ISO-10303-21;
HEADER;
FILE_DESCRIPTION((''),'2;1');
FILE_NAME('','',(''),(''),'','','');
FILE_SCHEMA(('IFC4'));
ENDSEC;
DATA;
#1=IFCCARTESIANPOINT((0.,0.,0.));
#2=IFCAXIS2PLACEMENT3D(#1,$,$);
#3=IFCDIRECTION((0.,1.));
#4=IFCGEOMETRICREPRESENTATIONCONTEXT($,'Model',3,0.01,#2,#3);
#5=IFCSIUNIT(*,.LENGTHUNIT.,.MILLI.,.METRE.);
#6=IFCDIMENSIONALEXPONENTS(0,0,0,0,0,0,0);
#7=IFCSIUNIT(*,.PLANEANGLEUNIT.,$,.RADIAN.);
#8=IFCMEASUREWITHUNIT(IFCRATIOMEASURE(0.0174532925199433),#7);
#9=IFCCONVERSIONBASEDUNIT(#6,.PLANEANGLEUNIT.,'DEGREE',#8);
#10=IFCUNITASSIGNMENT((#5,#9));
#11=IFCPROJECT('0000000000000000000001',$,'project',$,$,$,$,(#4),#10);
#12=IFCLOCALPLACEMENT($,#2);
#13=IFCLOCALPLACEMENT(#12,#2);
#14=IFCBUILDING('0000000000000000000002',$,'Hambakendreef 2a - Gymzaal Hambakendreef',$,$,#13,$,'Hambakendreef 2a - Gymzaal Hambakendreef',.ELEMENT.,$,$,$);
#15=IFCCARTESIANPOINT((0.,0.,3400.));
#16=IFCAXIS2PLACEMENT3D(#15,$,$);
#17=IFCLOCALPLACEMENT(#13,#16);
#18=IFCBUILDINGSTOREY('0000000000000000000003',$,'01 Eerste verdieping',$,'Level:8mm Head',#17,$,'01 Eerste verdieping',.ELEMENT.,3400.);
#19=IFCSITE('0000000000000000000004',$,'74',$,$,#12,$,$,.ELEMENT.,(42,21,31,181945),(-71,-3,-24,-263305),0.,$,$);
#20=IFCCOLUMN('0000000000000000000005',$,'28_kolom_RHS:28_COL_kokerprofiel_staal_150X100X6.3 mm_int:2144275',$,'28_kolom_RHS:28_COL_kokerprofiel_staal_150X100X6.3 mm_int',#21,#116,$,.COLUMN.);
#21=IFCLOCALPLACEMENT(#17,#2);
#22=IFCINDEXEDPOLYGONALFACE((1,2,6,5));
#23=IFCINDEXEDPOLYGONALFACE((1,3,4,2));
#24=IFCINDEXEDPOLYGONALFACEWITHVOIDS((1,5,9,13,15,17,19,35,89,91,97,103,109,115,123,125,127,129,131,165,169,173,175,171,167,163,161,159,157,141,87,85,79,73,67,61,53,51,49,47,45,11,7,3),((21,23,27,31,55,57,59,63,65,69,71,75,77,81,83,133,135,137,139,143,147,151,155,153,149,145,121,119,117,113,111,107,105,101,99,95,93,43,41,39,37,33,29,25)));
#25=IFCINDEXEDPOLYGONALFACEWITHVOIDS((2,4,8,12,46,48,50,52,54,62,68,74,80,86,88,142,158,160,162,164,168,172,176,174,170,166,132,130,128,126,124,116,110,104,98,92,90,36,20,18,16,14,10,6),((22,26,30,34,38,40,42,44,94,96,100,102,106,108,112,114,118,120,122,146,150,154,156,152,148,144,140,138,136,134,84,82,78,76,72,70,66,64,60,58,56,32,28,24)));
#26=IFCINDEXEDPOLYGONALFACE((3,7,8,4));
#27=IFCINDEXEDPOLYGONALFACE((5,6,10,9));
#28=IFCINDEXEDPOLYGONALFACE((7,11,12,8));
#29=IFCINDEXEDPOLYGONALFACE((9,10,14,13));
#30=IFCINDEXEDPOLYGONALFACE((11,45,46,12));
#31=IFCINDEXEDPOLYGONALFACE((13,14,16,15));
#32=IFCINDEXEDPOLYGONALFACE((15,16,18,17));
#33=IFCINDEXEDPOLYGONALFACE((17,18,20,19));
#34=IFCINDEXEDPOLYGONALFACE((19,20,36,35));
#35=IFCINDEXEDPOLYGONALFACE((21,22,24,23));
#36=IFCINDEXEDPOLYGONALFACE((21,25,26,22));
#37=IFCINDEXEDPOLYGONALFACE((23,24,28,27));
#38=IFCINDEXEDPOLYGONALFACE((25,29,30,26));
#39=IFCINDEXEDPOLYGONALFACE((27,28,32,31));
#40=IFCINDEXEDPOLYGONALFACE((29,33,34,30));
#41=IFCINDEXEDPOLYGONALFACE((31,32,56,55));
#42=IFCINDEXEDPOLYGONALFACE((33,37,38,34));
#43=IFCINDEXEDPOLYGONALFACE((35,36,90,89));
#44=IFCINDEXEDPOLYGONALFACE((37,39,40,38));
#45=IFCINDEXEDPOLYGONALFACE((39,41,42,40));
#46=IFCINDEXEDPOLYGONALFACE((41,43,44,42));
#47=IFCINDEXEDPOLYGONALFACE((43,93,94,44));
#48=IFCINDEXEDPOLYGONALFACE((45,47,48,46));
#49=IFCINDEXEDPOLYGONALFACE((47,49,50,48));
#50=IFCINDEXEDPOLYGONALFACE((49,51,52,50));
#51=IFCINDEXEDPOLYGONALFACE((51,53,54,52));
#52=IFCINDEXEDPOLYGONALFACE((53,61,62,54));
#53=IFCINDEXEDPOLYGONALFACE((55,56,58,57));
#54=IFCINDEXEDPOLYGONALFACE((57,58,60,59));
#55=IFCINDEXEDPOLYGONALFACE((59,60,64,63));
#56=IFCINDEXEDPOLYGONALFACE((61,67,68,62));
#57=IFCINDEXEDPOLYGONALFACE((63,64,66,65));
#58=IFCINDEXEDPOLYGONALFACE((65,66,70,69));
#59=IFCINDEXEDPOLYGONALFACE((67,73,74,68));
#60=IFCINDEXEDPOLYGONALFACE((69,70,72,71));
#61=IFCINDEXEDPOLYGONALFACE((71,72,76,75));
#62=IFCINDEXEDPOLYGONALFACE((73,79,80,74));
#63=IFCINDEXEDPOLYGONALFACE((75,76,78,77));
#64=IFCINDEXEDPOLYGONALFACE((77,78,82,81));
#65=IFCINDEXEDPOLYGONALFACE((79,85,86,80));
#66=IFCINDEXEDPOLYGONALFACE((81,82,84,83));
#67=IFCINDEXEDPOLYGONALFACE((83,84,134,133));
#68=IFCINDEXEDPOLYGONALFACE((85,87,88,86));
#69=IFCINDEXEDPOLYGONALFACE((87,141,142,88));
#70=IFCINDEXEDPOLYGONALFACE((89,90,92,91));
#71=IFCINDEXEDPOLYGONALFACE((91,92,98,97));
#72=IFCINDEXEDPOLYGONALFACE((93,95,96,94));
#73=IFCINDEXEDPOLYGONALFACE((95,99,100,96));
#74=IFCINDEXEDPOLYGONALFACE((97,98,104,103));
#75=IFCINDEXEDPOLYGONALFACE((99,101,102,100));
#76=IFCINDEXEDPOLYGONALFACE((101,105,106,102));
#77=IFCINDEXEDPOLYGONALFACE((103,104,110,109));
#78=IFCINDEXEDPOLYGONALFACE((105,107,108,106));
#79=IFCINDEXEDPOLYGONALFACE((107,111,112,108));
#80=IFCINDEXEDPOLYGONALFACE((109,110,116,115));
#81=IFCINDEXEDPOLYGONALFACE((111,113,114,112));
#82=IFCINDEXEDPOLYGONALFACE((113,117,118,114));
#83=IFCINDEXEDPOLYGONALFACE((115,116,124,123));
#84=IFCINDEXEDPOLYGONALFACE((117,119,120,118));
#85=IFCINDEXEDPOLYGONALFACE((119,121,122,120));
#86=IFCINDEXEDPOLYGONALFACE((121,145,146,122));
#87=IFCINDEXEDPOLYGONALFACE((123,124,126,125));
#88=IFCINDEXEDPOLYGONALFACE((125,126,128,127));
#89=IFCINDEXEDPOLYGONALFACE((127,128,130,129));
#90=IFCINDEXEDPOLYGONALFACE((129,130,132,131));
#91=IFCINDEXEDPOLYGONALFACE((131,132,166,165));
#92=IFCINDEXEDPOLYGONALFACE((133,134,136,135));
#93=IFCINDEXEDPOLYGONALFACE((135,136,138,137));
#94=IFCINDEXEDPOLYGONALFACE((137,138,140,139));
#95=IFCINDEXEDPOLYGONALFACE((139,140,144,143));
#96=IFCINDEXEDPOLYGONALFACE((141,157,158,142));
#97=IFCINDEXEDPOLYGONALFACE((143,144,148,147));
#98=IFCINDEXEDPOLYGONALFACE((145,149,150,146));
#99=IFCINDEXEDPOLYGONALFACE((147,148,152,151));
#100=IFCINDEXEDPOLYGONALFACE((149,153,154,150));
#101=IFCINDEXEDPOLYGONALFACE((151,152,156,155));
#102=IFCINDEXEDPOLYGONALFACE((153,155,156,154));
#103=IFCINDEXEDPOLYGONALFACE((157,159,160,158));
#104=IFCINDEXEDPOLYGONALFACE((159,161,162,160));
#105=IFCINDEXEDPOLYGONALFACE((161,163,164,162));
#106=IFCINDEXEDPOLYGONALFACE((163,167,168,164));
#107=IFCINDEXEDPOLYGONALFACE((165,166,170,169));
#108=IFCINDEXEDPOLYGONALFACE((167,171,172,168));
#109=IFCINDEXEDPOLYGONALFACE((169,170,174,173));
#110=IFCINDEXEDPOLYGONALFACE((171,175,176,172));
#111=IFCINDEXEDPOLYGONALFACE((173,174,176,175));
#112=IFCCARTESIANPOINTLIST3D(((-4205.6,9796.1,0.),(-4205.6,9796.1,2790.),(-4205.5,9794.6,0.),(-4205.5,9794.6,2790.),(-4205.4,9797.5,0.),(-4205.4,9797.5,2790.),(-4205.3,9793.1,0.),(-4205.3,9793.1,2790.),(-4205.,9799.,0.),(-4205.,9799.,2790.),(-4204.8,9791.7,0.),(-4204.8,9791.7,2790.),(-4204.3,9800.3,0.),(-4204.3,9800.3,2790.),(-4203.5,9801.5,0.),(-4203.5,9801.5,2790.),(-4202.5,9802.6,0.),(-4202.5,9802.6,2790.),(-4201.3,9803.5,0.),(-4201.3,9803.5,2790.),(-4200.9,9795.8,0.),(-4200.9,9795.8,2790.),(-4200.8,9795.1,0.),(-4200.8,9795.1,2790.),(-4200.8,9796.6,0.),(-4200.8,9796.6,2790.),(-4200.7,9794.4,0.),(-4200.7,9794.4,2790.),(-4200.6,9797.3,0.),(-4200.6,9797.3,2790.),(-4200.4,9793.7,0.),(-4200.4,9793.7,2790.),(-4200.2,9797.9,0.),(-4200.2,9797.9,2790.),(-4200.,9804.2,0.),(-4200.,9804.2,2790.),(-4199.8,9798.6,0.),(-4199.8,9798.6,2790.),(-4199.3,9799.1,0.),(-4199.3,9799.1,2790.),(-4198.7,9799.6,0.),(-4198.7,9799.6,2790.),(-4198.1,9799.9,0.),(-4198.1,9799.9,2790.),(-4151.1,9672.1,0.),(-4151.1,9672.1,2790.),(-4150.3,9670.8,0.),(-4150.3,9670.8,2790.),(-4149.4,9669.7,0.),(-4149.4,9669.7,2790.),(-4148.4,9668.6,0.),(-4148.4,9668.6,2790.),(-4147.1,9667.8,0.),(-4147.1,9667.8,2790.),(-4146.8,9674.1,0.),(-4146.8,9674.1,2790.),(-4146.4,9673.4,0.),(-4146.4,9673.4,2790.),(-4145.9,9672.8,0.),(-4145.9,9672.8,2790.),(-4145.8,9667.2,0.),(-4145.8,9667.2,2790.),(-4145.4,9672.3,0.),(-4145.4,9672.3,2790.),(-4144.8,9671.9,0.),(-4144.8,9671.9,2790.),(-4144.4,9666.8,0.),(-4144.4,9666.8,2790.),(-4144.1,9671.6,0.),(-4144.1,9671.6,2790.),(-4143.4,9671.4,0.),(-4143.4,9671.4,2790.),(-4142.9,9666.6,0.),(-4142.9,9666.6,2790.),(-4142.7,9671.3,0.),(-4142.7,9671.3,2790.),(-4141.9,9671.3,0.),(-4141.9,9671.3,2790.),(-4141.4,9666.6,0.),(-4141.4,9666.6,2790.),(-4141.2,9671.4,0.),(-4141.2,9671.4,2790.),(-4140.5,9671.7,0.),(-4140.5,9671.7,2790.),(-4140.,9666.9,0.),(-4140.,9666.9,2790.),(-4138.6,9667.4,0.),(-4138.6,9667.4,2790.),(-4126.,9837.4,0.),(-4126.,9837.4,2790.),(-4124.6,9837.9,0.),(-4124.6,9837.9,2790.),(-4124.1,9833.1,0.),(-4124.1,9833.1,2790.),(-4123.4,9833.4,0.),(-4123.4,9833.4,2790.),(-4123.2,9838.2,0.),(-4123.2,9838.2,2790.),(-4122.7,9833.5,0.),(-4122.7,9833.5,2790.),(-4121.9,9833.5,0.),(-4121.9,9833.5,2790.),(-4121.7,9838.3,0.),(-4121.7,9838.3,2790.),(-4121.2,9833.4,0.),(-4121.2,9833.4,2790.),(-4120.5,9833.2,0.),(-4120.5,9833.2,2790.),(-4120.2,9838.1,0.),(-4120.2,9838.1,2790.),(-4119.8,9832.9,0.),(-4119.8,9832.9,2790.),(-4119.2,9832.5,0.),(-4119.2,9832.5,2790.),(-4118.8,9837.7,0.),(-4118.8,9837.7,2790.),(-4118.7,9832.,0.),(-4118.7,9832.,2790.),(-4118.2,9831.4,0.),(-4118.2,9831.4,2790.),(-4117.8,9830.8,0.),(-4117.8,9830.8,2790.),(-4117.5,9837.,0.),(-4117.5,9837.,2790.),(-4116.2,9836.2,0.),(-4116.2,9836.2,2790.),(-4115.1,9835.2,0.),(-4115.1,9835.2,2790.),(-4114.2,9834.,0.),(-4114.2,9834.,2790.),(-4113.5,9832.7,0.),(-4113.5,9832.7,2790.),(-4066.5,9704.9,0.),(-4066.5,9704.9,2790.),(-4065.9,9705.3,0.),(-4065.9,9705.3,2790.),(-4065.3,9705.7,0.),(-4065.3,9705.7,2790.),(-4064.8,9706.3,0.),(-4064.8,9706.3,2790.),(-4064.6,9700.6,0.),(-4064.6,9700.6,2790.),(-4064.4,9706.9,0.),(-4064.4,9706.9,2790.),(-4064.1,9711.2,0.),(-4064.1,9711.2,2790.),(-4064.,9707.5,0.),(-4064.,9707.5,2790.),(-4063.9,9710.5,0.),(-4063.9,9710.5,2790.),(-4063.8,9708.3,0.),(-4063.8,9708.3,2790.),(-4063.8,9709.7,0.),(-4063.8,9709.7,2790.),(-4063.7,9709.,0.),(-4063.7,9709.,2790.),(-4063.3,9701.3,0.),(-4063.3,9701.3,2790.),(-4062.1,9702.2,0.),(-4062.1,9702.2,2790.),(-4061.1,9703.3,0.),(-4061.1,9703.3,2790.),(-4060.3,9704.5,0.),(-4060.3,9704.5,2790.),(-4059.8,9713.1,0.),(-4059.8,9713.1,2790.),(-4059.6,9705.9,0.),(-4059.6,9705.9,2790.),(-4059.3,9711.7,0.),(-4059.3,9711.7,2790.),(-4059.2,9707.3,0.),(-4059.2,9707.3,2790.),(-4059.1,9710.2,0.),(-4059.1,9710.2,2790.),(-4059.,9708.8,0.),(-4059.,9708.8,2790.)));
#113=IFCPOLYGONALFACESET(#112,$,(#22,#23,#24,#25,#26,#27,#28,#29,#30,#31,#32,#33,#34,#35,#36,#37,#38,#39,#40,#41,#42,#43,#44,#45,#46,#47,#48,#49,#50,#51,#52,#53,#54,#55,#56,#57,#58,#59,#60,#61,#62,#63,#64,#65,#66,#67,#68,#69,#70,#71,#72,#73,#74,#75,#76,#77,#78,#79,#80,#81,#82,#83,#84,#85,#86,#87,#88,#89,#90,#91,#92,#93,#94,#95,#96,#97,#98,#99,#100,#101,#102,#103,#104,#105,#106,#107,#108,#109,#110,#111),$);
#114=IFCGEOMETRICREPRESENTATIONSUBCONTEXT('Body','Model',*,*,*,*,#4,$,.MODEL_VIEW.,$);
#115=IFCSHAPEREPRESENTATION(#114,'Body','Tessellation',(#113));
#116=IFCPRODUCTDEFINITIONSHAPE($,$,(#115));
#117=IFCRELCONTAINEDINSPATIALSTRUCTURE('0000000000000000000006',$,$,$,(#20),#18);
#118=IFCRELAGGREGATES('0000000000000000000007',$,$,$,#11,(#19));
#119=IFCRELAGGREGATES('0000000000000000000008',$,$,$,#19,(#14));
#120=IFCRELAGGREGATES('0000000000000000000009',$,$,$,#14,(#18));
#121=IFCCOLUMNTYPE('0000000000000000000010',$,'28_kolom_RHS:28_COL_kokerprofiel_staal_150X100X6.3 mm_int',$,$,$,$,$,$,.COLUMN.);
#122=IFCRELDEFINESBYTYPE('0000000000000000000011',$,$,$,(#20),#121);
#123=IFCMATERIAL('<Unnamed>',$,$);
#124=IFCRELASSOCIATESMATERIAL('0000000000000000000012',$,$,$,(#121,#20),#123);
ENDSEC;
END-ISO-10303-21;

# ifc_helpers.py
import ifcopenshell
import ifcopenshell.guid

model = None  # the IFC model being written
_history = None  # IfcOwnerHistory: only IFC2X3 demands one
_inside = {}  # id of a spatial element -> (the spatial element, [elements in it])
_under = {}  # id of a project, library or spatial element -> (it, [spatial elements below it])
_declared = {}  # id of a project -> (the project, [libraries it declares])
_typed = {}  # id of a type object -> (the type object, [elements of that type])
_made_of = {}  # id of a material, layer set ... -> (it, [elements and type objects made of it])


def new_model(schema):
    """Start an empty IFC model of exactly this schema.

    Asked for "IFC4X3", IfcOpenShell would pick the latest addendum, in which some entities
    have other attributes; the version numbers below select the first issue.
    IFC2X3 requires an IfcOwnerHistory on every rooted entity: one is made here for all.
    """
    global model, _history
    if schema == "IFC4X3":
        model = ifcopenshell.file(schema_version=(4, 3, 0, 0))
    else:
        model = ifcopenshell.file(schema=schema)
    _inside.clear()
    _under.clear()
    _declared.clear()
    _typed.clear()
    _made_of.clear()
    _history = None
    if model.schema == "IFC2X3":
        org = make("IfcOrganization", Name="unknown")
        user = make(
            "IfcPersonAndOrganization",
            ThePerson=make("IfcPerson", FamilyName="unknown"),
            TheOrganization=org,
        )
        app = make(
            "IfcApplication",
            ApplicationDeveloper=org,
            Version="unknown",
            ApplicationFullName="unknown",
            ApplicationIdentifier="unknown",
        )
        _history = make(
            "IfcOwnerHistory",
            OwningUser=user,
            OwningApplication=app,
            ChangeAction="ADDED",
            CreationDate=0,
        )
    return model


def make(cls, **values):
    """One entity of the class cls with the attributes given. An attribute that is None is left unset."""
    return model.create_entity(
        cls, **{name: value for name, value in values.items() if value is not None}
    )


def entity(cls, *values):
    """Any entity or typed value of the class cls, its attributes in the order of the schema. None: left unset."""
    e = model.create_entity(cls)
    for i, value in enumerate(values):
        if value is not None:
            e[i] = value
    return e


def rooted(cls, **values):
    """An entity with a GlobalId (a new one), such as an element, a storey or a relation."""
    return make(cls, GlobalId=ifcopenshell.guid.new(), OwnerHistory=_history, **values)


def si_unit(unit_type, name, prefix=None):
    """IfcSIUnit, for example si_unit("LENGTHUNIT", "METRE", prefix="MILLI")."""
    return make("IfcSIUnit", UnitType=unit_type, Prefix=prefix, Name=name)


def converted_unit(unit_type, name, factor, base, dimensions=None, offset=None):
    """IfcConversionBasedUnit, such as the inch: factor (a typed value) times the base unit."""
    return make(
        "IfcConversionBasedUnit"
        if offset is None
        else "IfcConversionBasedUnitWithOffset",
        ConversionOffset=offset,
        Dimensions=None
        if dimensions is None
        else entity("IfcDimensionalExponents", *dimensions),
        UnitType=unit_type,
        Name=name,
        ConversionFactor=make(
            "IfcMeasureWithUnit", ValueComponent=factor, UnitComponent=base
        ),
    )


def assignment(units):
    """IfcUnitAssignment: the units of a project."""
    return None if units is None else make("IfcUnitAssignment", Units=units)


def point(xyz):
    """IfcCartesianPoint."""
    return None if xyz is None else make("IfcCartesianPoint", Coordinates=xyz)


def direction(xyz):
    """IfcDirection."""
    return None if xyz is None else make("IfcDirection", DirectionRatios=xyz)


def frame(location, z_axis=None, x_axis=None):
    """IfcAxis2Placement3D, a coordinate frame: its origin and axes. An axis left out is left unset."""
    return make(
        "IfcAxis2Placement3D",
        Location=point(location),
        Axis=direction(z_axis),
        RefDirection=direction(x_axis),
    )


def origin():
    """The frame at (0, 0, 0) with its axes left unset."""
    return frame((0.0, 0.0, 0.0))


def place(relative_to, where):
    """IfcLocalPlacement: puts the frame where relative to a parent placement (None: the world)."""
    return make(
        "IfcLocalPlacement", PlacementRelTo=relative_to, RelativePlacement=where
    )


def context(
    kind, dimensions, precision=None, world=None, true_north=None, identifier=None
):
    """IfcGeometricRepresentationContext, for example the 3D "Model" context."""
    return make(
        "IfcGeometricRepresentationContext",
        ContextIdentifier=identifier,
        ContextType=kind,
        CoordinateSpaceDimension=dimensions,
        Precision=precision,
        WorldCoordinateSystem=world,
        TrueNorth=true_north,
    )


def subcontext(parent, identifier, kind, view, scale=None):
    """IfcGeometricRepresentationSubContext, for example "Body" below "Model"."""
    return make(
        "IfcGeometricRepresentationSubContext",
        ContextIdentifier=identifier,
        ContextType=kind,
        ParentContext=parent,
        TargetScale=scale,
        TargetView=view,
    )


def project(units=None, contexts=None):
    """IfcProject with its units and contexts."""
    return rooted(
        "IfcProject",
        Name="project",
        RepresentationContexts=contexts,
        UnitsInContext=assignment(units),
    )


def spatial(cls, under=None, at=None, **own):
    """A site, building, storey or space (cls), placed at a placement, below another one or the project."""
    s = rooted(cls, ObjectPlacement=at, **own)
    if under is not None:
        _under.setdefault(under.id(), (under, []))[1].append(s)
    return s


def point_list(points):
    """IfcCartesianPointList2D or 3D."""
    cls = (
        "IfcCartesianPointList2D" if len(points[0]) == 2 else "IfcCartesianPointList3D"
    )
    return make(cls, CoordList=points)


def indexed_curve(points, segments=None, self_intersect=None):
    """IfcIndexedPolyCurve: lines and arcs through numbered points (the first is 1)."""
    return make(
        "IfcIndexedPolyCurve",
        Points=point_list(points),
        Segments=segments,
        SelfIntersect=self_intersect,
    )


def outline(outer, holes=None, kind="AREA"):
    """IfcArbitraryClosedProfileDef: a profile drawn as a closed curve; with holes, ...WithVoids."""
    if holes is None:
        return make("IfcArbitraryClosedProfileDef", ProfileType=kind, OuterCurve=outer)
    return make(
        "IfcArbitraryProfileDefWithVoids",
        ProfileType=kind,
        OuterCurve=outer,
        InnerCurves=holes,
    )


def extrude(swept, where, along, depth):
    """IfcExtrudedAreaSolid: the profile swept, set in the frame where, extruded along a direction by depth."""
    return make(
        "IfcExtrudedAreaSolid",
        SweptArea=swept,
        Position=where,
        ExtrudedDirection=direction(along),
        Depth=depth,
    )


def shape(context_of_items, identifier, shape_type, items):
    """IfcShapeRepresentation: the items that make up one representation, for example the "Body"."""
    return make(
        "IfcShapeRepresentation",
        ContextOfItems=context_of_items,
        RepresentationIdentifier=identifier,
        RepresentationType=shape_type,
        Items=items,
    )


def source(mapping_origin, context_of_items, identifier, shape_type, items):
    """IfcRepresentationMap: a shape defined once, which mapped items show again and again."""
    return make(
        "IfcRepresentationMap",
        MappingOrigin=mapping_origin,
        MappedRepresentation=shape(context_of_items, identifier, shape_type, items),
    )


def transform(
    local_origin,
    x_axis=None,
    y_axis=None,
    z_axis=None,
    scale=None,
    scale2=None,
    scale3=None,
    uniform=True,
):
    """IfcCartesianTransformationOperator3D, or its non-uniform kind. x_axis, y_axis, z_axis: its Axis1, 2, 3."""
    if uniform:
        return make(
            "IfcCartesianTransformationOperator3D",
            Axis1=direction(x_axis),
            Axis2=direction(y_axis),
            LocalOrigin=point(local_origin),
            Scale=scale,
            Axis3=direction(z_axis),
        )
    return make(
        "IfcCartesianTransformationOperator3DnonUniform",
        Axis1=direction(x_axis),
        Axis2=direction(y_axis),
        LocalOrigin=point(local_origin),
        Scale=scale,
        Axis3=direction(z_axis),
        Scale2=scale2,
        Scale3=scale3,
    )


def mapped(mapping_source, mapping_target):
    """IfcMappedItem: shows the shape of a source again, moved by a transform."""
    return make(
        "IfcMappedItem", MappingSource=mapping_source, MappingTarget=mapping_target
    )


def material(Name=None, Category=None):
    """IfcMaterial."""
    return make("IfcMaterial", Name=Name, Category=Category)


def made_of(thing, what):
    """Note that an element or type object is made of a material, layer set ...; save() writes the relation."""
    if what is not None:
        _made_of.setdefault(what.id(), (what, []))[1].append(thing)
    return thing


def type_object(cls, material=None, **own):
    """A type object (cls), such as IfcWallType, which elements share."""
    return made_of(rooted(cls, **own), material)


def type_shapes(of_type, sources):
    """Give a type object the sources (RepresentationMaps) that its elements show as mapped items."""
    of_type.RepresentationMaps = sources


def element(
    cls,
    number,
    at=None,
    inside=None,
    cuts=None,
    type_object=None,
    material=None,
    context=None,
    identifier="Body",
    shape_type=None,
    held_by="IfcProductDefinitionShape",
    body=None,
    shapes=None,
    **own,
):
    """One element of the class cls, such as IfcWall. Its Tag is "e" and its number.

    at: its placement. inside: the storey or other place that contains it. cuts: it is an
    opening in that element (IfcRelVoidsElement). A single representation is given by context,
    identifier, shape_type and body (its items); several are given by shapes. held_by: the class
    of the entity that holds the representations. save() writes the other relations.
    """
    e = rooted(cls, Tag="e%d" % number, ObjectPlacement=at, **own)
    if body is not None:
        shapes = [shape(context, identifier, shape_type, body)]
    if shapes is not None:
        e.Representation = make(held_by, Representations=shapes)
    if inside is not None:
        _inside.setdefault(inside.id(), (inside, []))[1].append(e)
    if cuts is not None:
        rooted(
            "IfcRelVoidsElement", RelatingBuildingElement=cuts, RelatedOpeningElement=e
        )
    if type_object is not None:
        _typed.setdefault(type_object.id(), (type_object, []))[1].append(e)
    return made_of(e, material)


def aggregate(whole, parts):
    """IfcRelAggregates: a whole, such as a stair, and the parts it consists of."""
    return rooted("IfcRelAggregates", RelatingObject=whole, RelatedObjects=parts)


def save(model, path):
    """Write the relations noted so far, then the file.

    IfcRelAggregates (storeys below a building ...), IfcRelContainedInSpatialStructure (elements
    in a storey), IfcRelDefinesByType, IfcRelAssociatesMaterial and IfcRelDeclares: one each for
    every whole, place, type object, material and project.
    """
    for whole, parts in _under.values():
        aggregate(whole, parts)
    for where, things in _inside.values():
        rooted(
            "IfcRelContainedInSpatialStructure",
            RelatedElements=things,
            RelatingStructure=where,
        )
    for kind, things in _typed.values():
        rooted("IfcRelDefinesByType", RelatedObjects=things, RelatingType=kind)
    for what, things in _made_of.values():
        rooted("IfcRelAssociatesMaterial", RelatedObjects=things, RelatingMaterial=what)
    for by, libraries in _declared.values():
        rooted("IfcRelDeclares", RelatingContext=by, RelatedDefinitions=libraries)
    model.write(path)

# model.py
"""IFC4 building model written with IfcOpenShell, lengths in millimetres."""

from ifc_helpers import new_model, entity, si_unit, converted_unit, direction, frame, origin, place, context, subcontext, project, spatial, indexed_curve, outline, extrude, source, transform, mapped, material, type_object, type_shapes, element, save


model = new_model("IFC4")

# Units and contexts
model_context = context("Model", 3, precision=0.01, world=origin(), true_north=direction((0.0, 1.0)))
body_context = subcontext(model_context, "Body", "Model", "MODEL_VIEW")
ifc_project = project(units=[si_unit("LENGTHUNIT", "METRE", prefix="MILLI"), converted_unit("PLANEANGLEUNIT", "DEGREE", entity("IfcRatioMeasure", 0.0174532925199433), si_unit("PLANEANGLEUNIT", "RADIAN"), dimensions=[0, 0, 0, 0, 0, 0, 0])], contexts=[model_context])

# Site, building, storey
site_placement = place(None, origin())
site = spatial("IfcSite", under=ifc_project, at=site_placement, Name="74", CompositionType="ELEMENT", RefLatitude=(42, 21, 31, 181945), RefLongitude=(-71, -3, -24, -263305), RefElevation=0.0)
building_placement = place(site_placement, origin())
building = spatial("IfcBuilding", under=site, at=building_placement, Name="Hambakendreef 2a - Gymzaal Hambakendreef", LongName="Hambakendreef 2a - Gymzaal Hambakendreef", CompositionType="ELEMENT")
storey_placement = place(building_placement, frame((0.0, 0.0, 3400.0)))
storey = spatial("IfcBuildingStorey", under=building, at=storey_placement, Name="01 Eerste verdieping", ObjectType="Level:8mm Head", LongName="01 Eerste verdieping", CompositionType="ELEMENT", Elevation=3400.0)

# Column
ifc_material_1 = material(Name="<Unnamed>")
column_type = type_object("IfcColumnType", Name="28_kolom_RHS:28_COL_kokerprofiel_staal_150X100X6.3 mm_int", PredefinedType="COLUMN", material=ifc_material_1)
shared_shape_1 = source(origin(), body_context, "Body", "SweptSolid", [
    extrude(outline(indexed_curve([(-40.5, -75.0), (40.5, -75.0), (42.0, -74.9), (43.5, -74.5), (44.8, -74.0), (46.1, -73.2), (47.2, -72.2), (48.2, -71.1), (49.0, -69.8), (49.5, -68.5), (49.9, -67.0), (50.0, -65.6), (50.0, 65.6), (49.9, 67.0), (49.5, 68.5), (49.0, 69.8), (48.2, 71.1), (47.2, 72.2), (46.1, 73.2), (44.8, 74.0), (43.5, 74.5), (42.0, 74.9), (40.5, 75.0), (-40.5, 75.0), (-42.0, 74.9), (-43.5, 74.5), (-44.8, 74.0), (-46.1, 73.2), (-47.2, 72.2), (-48.2, 71.1), (-49.0, 69.8), (-49.5, 68.5), (-49.9, 67.0), (-50.0, 65.6), (-50.0, -65.6), (-49.9, -67.0), (-49.5, -68.5), (-49.0, -69.8), (-48.2, -71.1), (-47.2, -72.2), (-46.1, -73.2), (-44.8, -74.0), (-43.5, -74.5), (-42.0, -74.9), (-40.5, -75.0)], self_intersect=False), holes=[indexed_curve([(-45.3, 65.5), (-45.2, 66.3), (-45.0, 67.0), (-44.8, 67.7), (-44.4, 68.3), (-43.9, 68.9), (-43.3, 69.4), (-42.7, 69.8), (-42.0, 70.0), (-41.3, 70.2), (-40.6, 70.3), (40.5, 70.3), (41.3, 70.2), (42.0, 70.0), (42.7, 69.8), (43.3, 69.4), (43.9, 68.9), (44.4, 68.3), (44.8, 67.7), (45.0, 67.0), (45.2, 66.3), (45.3, 65.5), (45.3, -65.5), (45.2, -66.3), (45.0, -67.0), (44.8, -67.7), (44.4, -68.3), (43.9, -68.9), (43.3, -69.4), (42.7, -69.8), (42.0, -70.0), (41.3, -70.2), (40.5, -70.3), (-40.6, -70.3), (-41.3, -70.2), (-42.0, -70.0), (-42.7, -69.8), (-43.3, -69.4), (-43.9, -68.9), (-44.4, -68.3), (-44.8, -67.7), (-45.0, -67.0), (-45.2, -66.3), (-45.3, -65.5), (-45.3, 65.5)], self_intersect=False)]), frame((235.6, 34.3, 3400.0), z_axis=(0.0, 0.0, 1.0), x_axis=(0.0, 1.0, 0.0)), (0.0, 0.0, 1.0), 2790.0),
])
type_shapes(column_type, [shared_shape_1])
for number, where, z_axis, x_axis, name in (
    (1, (-4260.0, 9953.3, -3400.0), (0.0, 0.0, 1.0), (0.40959, -0.91227, 0.0), "28_kolom_RHS:28_COL_kokerprofiel_staal_150X100X6.3 mm_int:2144275"),
):
    element("IfcColumn", number, at=place(storey_placement, frame(where, z_axis=z_axis, x_axis=x_axis)), inside=storey, type_object=column_type, material=ifc_material_1, Name=name, ObjectType="28_kolom_RHS:28_COL_kokerprofiel_staal_150X100X6.3 mm_int", PredefinedType="COLUMN", context=body_context, shape_type="MappedRepresentation", body=[
        mapped(shared_shape_1, transform((0.0, 0.0, 0.0), scale=1.0)),
    ])

save(model, "model.ifc")
